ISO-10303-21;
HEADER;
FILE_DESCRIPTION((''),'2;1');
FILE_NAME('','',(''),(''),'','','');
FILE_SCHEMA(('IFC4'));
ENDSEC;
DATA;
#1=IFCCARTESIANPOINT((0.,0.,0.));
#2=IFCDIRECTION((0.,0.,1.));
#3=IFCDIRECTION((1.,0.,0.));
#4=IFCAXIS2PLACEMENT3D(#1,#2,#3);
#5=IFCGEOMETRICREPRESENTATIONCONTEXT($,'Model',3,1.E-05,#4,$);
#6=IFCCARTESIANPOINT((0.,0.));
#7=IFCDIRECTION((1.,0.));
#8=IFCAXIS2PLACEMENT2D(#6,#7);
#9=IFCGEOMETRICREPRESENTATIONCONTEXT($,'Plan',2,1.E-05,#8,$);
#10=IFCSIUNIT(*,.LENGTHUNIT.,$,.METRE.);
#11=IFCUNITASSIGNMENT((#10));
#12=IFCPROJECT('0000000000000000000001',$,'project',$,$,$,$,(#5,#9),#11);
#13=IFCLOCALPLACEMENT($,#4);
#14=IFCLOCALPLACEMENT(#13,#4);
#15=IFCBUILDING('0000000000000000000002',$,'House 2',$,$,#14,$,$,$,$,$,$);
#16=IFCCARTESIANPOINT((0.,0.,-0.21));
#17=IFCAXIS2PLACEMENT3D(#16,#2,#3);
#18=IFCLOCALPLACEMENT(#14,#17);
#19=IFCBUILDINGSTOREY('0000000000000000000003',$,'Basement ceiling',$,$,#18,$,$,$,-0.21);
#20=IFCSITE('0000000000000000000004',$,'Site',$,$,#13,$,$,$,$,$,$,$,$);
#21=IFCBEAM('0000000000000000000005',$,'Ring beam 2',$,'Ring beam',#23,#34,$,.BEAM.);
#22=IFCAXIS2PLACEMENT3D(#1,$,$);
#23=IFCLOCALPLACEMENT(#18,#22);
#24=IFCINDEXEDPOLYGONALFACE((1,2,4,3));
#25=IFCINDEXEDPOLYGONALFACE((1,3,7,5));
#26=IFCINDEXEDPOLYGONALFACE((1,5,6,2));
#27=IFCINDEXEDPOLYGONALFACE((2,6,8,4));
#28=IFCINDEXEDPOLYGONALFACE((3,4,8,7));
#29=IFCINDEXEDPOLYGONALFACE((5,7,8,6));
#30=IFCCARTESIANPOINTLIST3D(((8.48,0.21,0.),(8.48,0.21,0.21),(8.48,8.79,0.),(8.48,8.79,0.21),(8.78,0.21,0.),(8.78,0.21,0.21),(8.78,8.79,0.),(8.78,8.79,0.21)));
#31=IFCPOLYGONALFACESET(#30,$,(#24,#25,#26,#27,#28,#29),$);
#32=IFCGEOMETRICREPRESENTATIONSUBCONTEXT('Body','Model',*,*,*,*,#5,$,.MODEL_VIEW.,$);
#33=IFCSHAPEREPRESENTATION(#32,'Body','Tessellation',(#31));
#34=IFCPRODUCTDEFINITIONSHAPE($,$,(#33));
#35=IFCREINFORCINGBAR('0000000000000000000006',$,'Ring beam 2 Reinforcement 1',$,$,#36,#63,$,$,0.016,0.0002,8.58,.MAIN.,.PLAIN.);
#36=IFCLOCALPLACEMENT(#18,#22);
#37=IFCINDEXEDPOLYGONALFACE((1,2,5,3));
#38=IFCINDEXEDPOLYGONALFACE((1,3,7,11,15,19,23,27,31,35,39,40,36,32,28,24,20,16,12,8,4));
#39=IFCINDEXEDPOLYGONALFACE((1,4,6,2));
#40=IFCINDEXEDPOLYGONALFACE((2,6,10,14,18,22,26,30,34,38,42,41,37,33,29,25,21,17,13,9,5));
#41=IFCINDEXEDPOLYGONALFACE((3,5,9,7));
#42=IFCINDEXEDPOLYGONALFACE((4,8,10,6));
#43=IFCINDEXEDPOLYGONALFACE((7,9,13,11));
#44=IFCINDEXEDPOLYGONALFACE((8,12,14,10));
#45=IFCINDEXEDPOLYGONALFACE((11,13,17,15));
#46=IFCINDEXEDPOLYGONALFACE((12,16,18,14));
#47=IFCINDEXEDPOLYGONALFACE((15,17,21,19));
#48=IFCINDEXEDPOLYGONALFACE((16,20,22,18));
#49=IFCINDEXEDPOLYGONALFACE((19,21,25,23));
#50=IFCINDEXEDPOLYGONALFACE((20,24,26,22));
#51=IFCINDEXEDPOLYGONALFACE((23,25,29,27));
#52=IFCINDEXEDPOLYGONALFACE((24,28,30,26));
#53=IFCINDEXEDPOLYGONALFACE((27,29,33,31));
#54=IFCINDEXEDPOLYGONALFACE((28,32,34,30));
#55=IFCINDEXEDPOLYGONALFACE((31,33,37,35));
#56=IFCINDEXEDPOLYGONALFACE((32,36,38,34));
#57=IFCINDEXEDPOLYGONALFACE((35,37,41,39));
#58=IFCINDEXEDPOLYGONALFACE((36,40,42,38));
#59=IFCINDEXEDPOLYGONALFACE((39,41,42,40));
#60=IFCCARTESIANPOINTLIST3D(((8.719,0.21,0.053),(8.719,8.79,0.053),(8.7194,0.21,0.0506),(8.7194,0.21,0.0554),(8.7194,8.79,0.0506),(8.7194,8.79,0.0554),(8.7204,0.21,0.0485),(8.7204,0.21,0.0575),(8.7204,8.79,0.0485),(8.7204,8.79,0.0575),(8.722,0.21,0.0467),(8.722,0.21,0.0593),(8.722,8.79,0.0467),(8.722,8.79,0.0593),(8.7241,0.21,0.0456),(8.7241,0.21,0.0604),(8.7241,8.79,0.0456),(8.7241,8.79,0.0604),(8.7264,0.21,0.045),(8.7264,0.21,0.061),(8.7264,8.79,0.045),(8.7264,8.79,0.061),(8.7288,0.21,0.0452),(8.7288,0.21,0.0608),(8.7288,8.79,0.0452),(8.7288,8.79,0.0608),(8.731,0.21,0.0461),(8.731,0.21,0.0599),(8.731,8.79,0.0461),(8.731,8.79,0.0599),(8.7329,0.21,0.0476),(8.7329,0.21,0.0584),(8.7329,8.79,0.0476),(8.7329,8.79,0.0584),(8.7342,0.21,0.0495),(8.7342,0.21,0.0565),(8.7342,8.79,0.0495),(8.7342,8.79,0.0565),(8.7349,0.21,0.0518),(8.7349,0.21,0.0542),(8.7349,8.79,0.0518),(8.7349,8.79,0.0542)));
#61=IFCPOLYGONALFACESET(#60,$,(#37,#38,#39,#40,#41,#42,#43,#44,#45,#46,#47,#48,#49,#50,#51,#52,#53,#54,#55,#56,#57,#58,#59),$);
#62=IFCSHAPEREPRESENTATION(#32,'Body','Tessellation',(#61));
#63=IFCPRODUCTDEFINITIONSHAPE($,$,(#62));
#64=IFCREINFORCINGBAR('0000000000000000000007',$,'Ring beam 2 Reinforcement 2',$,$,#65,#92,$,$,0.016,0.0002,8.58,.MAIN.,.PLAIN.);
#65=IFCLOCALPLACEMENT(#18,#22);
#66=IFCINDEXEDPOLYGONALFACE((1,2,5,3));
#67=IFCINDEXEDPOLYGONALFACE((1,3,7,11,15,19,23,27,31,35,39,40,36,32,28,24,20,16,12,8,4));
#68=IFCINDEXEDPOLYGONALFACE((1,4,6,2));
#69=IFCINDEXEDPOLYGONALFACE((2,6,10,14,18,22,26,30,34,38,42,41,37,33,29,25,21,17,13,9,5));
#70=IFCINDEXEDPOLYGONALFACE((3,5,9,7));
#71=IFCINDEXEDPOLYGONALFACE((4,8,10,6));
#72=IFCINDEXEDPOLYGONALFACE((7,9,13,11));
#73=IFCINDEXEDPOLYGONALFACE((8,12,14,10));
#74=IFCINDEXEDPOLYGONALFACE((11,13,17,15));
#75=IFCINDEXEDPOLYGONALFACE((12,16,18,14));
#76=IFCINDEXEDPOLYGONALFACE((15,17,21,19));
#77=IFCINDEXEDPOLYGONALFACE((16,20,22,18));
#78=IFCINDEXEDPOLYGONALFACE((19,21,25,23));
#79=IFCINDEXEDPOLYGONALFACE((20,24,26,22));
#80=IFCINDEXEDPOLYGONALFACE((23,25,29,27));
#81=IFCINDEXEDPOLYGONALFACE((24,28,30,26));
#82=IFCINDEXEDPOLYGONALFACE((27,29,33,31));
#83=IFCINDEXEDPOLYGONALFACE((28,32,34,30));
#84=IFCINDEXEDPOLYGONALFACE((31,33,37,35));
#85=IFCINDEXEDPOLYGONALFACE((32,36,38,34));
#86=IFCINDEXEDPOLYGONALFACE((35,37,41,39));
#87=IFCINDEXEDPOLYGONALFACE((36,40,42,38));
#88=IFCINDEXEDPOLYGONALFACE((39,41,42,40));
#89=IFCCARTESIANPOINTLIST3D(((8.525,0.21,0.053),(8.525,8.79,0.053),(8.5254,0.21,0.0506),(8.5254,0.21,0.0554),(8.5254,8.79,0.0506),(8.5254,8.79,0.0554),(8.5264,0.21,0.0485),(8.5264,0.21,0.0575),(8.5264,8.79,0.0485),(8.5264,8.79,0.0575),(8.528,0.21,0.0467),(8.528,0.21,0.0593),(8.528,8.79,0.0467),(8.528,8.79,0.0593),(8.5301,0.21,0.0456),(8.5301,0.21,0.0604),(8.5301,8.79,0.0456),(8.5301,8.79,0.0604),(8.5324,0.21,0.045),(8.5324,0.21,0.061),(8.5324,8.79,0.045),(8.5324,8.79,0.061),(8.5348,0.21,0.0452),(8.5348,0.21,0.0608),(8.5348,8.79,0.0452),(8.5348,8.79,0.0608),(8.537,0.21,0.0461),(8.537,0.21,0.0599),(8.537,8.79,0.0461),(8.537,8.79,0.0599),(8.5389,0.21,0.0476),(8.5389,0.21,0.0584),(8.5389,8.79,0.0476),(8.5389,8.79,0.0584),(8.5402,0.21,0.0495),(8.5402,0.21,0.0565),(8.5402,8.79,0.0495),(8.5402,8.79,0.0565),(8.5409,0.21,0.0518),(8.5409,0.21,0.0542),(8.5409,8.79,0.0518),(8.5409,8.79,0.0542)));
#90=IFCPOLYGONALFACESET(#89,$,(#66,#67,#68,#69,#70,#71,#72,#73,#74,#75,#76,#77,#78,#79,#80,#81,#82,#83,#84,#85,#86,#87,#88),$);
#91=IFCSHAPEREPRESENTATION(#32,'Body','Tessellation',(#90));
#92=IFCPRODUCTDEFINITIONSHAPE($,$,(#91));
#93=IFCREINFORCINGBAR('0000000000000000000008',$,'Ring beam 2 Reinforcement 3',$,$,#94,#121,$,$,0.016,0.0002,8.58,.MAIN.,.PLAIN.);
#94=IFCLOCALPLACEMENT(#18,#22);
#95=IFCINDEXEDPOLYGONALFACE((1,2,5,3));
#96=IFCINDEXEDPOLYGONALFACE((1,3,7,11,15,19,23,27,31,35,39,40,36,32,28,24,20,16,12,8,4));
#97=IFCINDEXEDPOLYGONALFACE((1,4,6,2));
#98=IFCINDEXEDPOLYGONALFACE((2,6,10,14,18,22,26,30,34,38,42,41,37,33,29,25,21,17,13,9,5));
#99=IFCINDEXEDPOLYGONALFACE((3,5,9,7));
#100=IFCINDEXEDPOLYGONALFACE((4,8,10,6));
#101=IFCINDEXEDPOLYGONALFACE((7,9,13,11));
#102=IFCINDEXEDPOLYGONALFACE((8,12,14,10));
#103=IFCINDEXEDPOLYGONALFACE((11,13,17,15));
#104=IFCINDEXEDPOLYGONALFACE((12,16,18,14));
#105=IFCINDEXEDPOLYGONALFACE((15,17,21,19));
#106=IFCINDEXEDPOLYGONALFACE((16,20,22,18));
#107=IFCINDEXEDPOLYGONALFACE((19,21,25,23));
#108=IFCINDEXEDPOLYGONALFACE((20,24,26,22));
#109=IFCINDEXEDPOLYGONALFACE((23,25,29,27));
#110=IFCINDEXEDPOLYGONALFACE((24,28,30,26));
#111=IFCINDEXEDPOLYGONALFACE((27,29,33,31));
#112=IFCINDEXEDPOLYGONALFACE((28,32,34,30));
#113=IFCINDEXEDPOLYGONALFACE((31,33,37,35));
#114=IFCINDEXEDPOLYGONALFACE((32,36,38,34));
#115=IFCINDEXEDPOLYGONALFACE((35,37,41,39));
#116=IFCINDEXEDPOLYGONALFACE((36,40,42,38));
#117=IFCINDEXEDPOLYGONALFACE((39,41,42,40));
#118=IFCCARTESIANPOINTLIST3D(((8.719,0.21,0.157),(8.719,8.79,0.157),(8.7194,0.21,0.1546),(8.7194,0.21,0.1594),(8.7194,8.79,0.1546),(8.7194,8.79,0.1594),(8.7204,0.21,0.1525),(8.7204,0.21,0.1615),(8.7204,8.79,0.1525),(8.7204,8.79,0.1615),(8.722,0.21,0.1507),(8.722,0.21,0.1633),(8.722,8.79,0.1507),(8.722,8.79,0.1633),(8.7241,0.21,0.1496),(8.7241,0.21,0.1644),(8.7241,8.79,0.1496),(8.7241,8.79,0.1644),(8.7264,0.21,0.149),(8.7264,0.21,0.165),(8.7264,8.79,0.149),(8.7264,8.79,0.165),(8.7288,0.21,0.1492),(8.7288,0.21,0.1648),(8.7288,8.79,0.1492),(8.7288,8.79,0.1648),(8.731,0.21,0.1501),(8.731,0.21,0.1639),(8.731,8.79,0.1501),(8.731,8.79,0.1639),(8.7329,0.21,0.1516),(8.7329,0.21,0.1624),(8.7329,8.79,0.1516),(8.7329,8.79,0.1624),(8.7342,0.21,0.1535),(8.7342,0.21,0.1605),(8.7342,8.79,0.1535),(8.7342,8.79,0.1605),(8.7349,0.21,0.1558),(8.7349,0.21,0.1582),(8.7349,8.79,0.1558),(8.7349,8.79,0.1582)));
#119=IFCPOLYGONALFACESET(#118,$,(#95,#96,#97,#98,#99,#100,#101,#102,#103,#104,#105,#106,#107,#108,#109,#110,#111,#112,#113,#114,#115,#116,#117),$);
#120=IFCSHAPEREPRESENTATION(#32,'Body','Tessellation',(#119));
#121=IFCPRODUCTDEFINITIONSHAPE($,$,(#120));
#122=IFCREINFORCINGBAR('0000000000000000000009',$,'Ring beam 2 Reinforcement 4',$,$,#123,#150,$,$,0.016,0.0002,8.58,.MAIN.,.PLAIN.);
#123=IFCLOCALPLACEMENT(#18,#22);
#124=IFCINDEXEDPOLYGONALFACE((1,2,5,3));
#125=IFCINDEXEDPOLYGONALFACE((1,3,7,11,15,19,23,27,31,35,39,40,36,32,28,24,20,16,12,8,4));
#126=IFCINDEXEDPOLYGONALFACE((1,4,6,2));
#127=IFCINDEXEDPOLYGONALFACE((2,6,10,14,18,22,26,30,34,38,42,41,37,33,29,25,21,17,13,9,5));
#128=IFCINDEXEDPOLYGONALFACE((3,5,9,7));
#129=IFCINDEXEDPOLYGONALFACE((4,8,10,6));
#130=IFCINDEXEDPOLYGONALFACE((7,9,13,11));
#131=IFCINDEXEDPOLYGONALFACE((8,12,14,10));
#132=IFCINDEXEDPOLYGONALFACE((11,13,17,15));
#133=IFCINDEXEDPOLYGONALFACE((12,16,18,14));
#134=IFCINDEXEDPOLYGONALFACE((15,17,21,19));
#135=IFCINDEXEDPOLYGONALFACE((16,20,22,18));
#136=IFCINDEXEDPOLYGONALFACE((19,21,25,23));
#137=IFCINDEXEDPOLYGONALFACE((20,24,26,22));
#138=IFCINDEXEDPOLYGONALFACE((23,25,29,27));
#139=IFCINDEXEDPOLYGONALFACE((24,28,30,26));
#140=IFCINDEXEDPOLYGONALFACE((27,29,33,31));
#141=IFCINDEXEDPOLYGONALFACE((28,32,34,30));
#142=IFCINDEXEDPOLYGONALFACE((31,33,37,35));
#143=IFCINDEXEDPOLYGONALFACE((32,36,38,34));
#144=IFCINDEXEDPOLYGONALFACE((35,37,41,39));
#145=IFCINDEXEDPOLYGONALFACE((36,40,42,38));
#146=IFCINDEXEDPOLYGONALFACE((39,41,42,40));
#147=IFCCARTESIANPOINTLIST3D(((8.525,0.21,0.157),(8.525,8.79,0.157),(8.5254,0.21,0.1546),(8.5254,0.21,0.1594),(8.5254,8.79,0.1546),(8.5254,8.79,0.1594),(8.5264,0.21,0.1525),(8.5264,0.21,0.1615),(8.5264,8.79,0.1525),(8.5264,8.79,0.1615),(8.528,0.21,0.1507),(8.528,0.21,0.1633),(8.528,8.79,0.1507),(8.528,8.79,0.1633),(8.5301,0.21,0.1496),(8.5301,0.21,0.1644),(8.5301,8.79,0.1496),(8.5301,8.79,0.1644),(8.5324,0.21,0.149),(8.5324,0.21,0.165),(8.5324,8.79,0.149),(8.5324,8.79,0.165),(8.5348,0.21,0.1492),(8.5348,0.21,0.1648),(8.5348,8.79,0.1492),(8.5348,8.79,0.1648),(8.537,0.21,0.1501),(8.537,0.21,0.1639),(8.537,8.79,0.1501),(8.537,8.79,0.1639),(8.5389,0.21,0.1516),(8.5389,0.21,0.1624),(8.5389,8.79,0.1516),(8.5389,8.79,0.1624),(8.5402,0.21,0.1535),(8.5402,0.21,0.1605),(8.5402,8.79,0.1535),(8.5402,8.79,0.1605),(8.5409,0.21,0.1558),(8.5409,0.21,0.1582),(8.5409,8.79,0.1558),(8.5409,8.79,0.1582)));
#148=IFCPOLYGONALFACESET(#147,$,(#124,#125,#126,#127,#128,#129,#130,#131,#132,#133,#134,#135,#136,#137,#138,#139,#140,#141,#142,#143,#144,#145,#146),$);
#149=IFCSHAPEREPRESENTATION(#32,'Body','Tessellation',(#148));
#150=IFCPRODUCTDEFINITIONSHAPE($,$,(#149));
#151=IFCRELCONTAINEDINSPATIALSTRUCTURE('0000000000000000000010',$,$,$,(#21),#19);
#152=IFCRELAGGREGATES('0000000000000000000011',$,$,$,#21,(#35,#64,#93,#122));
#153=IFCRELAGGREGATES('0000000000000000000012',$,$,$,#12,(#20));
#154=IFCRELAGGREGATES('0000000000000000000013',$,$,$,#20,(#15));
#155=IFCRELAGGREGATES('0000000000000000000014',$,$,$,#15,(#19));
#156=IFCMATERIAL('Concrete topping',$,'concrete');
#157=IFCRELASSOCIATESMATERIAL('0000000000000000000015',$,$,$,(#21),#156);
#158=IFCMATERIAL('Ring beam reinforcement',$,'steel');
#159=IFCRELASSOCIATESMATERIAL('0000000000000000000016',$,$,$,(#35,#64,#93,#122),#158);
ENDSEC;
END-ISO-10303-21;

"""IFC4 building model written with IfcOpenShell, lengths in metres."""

from ifc_helpers import new_model, si_unit, frame, origin_with_axes, origin_2d, origin_2d_with_axis, place, context, subcontext, project, spatial, circle_curve, rectangle, outline, extrude, material, element, aggregate, save


model = new_model("IFC4")

# Units and contexts
model_context = context("Model", 3, precision=1e-05, world=origin_with_axes())
plan_context = context("Plan", 2, precision=1e-05, world=origin_2d_with_axis())
body_context = subcontext(model_context, "Body", "Model", "MODEL_VIEW")
ifc_project = project(units=[si_unit("LENGTHUNIT", "METRE")], contexts=[model_context, plan_context])

# Site, building, storey
site_placement = place(None, origin_with_axes())
site = spatial("IfcSite", under=ifc_project, at=site_placement, Name="Site")
building_placement = place(site_placement, origin_with_axes())
building = spatial("IfcBuilding", under=site, at=building_placement, Name="House 2")
storey_placement = place(building_placement, frame((0.0, 0.0, -0.21), z_axis=(0.0, 0.0, 1.0), x_axis=(1.0, 0.0, 0.0)))
storey = spatial("IfcBuildingStorey", under=building, at=storey_placement, Name="Basement ceiling", Elevation=-0.21)

# Beam
ifc_material_1 = material(Name="Concrete topping", Category="concrete")
beam_1_placement = place(storey_placement, frame((8.63, 0.21, 0.105), z_axis=(0.0, 0.0, 1.0), x_axis=(0.0, 1.0, 0.0)))
beam_1 = element("IfcBeam", 1, at=beam_1_placement, inside=storey, material=ifc_material_1, Name="Ring beam 2", ObjectType="Ring beam", PredefinedType="BEAM", context=body_context, shape_type="SweptSolid", body=[
    extrude(rectangle(XDim=0.3, YDim=0.21), frame((0.0, 0.0, 0.0), z_axis=(1.0, 0.0, 0.0), x_axis=(0.0, 1.0, 0.0)), (0.0, 0.0, 1.0), 8.58),
])

# Reinforcing bars
ifc_material_2 = material(Name="Ring beam reinforcement", Category="steel")
reinforcing_bar_1_placement = place(beam_1_placement, frame((0.0, -0.097, -0.052), z_axis=(0.0, 0.0, 1.0), x_axis=(1.0, 0.0, 0.0)))
reinforcing_bar_1 = element("IfcReinforcingBar", 2, at=reinforcing_bar_1_placement, material=ifc_material_2, Name="Ring beam 2 Reinforcement 1", BarLength=8.58, BarSurface="PLAIN", CrossSectionArea=0.0002, NominalDiameter=0.016, PredefinedType="MAIN", context=body_context, shape_type="SweptSolid", body=[
    extrude(outline(circle_curve(origin_2d(), 0.008)), frame((0.0, 0.0, 0.0), z_axis=(1.0, 0.0, 0.0), x_axis=(0.0, 1.0, 0.0)), (0.0, 0.0, 1.0), 8.58),
])
reinforcing_bar_2_placement = place(beam_1_placement, frame((0.0, 0.097, -0.052), z_axis=(0.0, 0.0, 1.0), x_axis=(1.0, 0.0, 0.0)))
reinforcing_bar_2 = element("IfcReinforcingBar", 3, at=reinforcing_bar_2_placement, material=ifc_material_2, Name="Ring beam 2 Reinforcement 2", BarLength=8.58, BarSurface="PLAIN", CrossSectionArea=0.0002, NominalDiameter=0.016, PredefinedType="MAIN", context=body_context, shape_type="SweptSolid", body=[
    extrude(outline(circle_curve(origin_2d(), 0.008)), frame((0.0, 0.0, 0.0), z_axis=(1.0, 0.0, 0.0), x_axis=(0.0, 1.0, 0.0)), (0.0, 0.0, 1.0), 8.58),
])
reinforcing_bar_3_placement = place(beam_1_placement, frame((0.0, -0.097, 0.052), z_axis=(0.0, 0.0, 1.0), x_axis=(1.0, 0.0, 0.0)))
reinforcing_bar_3 = element("IfcReinforcingBar", 4, at=reinforcing_bar_3_placement, material=ifc_material_2, Name="Ring beam 2 Reinforcement 3", BarLength=8.58, BarSurface="PLAIN", CrossSectionArea=0.0002, NominalDiameter=0.016, PredefinedType="MAIN", context=body_context, shape_type="SweptSolid", body=[
    extrude(outline(circle_curve(origin_2d(), 0.008)), frame((0.0, 0.0, 0.0), z_axis=(1.0, 0.0, 0.0), x_axis=(0.0, 1.0, 0.0)), (0.0, 0.0, 1.0), 8.58),
])
reinforcing_bar_4_placement = place(beam_1_placement, frame((0.0, 0.097, 0.052), z_axis=(0.0, 0.0, 1.0), x_axis=(1.0, 0.0, 0.0)))
reinforcing_bar_4 = element("IfcReinforcingBar", 5, at=reinforcing_bar_4_placement, material=ifc_material_2, Name="Ring beam 2 Reinforcement 4", BarLength=8.58, BarSurface="PLAIN", CrossSectionArea=0.0002, NominalDiameter=0.016, PredefinedType="MAIN", context=body_context, shape_type="SweptSolid", body=[
    extrude(outline(circle_curve(origin_2d(), 0.008)), frame((0.0, 0.0, 0.0), z_axis=(1.0, 0.0, 0.0), x_axis=(0.0, 1.0, 0.0)), (0.0, 0.0, 1.0), 8.58),
])
aggregate(beam_1, [reinforcing_bar_1, reinforcing_bar_2, reinforcing_bar_3, reinforcing_bar_4])

save(model, "model.ifc")
